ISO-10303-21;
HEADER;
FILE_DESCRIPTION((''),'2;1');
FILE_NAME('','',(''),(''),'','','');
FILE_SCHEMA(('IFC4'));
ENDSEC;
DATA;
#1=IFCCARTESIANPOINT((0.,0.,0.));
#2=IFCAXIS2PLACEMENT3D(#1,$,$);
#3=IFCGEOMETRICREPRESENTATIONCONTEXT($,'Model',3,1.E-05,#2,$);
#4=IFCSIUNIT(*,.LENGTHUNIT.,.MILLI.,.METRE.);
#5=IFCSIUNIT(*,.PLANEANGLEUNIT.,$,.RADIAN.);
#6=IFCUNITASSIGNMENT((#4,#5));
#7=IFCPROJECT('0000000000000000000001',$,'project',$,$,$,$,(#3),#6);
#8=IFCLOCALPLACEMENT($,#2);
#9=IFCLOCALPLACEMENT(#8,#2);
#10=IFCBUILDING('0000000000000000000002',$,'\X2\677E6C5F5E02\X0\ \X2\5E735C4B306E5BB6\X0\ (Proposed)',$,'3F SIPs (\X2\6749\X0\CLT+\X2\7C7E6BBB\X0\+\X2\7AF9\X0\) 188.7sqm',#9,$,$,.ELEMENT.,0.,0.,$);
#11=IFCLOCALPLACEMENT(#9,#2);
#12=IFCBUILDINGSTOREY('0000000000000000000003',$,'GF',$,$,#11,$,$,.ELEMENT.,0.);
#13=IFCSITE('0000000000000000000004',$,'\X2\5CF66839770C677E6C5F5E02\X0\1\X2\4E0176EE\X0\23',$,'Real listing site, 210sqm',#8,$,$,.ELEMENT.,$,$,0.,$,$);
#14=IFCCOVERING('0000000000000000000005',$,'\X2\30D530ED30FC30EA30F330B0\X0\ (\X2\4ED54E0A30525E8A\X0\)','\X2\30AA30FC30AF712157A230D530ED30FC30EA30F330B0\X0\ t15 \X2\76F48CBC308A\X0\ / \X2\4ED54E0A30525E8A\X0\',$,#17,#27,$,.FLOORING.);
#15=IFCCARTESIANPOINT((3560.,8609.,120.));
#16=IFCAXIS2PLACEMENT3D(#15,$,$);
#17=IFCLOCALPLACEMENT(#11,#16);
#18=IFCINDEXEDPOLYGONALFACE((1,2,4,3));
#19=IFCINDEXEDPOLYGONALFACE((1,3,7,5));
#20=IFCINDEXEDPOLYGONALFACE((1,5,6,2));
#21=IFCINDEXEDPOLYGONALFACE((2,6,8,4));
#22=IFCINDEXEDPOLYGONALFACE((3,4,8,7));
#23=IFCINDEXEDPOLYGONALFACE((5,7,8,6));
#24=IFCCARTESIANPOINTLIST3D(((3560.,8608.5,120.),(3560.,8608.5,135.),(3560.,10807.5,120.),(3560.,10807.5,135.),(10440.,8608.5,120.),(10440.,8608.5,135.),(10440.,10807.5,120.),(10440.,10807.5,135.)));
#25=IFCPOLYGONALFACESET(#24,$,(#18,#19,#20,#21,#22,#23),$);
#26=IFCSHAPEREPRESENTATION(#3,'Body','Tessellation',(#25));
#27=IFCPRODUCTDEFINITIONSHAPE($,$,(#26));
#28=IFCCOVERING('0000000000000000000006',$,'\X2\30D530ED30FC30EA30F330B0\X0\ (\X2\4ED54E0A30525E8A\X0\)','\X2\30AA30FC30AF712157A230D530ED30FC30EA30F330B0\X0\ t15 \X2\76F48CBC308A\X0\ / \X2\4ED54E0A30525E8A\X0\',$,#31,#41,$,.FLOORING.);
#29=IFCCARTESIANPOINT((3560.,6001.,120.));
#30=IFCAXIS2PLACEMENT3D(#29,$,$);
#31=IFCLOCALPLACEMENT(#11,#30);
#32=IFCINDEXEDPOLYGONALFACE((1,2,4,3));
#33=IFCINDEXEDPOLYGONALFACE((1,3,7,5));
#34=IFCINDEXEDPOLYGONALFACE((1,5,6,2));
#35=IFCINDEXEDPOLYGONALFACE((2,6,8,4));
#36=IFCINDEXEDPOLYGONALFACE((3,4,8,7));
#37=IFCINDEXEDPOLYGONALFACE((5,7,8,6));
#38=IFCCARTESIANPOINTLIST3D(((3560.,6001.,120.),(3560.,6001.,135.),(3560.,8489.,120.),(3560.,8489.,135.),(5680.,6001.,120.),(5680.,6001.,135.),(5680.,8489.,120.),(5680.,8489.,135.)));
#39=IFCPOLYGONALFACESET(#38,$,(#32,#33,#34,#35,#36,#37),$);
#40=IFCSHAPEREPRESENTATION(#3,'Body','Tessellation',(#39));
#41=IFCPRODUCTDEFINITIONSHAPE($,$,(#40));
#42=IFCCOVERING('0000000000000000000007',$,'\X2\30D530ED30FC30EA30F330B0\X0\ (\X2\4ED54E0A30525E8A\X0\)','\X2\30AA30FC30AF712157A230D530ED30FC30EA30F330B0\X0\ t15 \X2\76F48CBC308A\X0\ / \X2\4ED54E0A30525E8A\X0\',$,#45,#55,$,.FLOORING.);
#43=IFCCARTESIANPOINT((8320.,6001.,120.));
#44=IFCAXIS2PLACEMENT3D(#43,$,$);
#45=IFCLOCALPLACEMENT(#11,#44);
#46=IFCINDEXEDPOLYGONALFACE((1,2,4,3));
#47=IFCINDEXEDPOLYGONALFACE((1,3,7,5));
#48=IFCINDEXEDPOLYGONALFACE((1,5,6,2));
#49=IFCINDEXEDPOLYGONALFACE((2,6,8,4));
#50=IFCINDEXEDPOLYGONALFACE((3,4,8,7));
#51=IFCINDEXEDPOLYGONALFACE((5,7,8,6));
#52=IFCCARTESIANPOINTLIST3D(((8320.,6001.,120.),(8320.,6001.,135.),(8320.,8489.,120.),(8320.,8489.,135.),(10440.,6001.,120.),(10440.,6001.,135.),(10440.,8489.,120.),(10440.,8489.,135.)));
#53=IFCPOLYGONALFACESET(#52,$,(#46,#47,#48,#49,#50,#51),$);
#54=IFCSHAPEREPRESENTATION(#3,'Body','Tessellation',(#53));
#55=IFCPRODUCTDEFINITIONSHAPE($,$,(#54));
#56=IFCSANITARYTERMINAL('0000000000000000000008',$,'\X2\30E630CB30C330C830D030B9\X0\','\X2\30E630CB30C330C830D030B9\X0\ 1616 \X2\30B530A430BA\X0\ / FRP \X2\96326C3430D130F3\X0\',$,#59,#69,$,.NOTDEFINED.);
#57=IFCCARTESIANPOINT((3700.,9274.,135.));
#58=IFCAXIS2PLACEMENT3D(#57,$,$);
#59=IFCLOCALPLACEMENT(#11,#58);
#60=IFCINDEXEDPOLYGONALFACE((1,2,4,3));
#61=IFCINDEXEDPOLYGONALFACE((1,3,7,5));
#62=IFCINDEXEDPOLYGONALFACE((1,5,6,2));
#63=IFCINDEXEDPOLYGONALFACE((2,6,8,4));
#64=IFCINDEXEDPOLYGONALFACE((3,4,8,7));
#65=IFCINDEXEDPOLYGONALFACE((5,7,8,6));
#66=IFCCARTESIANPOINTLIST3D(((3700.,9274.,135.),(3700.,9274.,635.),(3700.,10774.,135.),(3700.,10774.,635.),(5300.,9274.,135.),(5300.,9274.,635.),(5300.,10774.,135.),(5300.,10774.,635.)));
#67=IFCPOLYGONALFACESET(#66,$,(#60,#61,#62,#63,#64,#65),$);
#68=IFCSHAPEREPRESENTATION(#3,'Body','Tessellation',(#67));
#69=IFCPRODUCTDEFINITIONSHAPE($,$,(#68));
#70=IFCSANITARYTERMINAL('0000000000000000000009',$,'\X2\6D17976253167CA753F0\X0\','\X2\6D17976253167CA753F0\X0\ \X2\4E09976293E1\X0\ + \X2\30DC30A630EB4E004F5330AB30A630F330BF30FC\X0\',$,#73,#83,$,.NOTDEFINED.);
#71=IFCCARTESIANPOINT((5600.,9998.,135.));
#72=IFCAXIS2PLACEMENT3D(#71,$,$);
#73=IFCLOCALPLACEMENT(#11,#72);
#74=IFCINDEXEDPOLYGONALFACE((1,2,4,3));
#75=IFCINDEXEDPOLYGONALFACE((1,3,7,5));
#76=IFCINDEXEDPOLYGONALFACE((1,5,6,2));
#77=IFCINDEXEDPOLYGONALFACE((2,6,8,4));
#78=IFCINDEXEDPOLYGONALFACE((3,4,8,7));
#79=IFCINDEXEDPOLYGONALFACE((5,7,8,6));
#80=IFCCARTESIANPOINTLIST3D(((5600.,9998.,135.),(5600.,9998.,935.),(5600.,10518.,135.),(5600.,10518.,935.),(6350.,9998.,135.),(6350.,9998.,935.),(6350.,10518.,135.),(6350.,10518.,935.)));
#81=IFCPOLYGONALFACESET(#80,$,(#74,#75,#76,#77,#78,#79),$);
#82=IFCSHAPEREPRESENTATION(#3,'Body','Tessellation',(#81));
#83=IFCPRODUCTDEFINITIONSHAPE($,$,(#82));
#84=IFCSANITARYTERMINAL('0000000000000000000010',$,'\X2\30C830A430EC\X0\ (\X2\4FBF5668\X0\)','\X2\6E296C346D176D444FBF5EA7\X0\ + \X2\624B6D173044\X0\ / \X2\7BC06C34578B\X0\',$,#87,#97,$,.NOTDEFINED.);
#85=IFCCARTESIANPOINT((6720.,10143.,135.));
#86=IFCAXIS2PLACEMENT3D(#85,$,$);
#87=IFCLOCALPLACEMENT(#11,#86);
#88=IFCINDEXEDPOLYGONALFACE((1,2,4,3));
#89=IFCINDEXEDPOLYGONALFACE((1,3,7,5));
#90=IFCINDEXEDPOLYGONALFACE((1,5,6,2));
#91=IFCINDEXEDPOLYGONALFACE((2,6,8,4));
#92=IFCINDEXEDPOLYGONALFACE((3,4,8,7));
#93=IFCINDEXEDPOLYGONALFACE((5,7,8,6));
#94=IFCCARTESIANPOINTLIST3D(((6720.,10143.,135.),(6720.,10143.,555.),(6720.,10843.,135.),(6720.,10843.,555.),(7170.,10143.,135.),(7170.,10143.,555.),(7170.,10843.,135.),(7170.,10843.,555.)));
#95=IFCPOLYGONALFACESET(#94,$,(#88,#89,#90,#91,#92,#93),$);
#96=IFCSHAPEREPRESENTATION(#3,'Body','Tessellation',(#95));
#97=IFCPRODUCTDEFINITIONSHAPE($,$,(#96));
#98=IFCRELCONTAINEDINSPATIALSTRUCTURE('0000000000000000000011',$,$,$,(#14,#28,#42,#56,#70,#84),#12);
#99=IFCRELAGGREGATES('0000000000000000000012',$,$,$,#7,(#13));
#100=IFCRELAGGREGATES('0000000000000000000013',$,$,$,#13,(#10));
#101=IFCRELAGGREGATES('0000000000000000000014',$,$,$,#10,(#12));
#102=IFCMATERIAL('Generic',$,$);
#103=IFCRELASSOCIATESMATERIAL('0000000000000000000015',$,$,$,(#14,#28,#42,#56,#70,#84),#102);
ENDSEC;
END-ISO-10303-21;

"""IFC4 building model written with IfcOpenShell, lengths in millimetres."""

from ifc_helpers import new_model, si_unit, frame, frame_2d, origin, place, context, project, spatial, rectangle, extrude, material, element, save


model = new_model("IFC4")

# Units and contexts
model_context = context("Model", 3, precision=1e-05, world=origin())
ifc_project = project(units=[si_unit("LENGTHUNIT", "METRE", prefix="MILLI"), si_unit("PLANEANGLEUNIT", "RADIAN")], contexts=[model_context])

# Site, building, storey
site_placement = place(None, origin())
site = spatial("IfcSite", under=ifc_project, at=site_placement, Name="島根県松江市1丁目23", ObjectType="Real listing site, 210sqm", CompositionType="ELEMENT", RefElevation=0.0)
building_placement = place(site_placement, origin())
building = spatial("IfcBuilding", under=site, at=building_placement, Name="松江市 平屋の家 (Proposed)", ObjectType="3F SIPs (杉CLT+籾殻+竹) 188.7sqm", CompositionType="ELEMENT", ElevationOfRefHeight=0.0, ElevationOfTerrain=0.0)
storey_placement = place(building_placement, origin())
storey = spatial("IfcBuildingStorey", under=building, at=storey_placement, Name="GF", CompositionType="ELEMENT", Elevation=0.0)

# Coverings
ifc_material_1 = material(Name="Generic")
covering_1_placement = place(storey_placement, frame((3560.0, 8609.0, 120.0)))
element("IfcCovering", 1, at=covering_1_placement, inside=storey, material=ifc_material_1, Name="フローリング (仕上げ床)", Description="オーク無垢フローリング t15 直貼り / 仕上げ床", PredefinedType="FLOORING", context=model_context, shape_type="SweptSolid", body=[
    extrude(rectangle(XDim=6880.0, YDim=2199.0, at=frame_2d((3440.0, 1099.0))), frame((3560.0, 8609.0, 120.0)), (0.0, 0.0, 1.0), 15.0),
])
covering_2_placement = place(storey_placement, frame((3560.0, 6001.0, 120.0)))
element("IfcCovering", 2, at=covering_2_placement, inside=storey, material=ifc_material_1, Name="フローリング (仕上げ床)", Description="オーク無垢フローリング t15 直貼り / 仕上げ床", PredefinedType="FLOORING", context=model_context, shape_type="SweptSolid", body=[
    extrude(rectangle(XDim=2120.0, YDim=2488.0, at=frame_2d((1060.0, 1244.0))), frame((3560.0, 6001.0, 120.0)), (0.0, 0.0, 1.0), 15.0),
])
covering_3_placement = place(storey_placement, frame((8320.0, 6001.0, 120.0)))
element("IfcCovering", 3, at=covering_3_placement, inside=storey, material=ifc_material_1, Name="フローリング (仕上げ床)", Description="オーク無垢フローリング t15 直貼り / 仕上げ床", PredefinedType="FLOORING", context=model_context, shape_type="SweptSolid", body=[
    extrude(rectangle(XDim=2120.0, YDim=2488.0, at=frame_2d((1060.0, 1244.0))), frame((8320.0, 6001.0, 120.0)), (0.0, 0.0, 1.0), 15.0),
])

# Sanitary terminals
sanitary_terminal_1_placement = place(storey_placement, frame((3700.0, 9274.0, 135.0)))
element("IfcSanitaryTerminal", 4, at=sanitary_terminal_1_placement, inside=storey, material=ifc_material_1, Name="ユニットバス", Description="ユニットバス 1616 サイズ / FRP 防水パン", PredefinedType="NOTDEFINED", context=model_context, shape_type="SweptSolid", body=[
    extrude(rectangle(XDim=1600.0, YDim=1500.0, at=frame_2d((800.0, 750.0))), frame((3700.0, 9274.0, 135.0)), (0.0, 0.0, 1.0), 500.0),
])
sanitary_terminal_2_placement = place(storey_placement, frame((5600.0, 9998.0, 135.0)))
element("IfcSanitaryTerminal", 5, at=sanitary_terminal_2_placement, inside=storey, material=ifc_material_1, Name="洗面化粧台", Description="洗面化粧台 三面鏡 + ボウル一体カウンター", PredefinedType="NOTDEFINED", context=model_context, shape_type="SweptSolid", body=[
    extrude(rectangle(XDim=750.0, YDim=520.0, at=frame_2d((375.0, 260.0))), frame((5600.0, 9998.0, 135.0)), (0.0, 0.0, 1.0), 800.0),
])
sanitary_terminal_3_placement = place(storey_placement, frame((6720.0, 10143.0, 135.0)))
element("IfcSanitaryTerminal", 6, at=sanitary_terminal_3_placement, inside=storey, material=ifc_material_1, Name="トイレ (便器)", Description="温水洗浄便座 + 手洗い / 節水型", PredefinedType="NOTDEFINED", context=model_context, shape_type="SweptSolid", body=[
    extrude(rectangle(XDim=450.0, YDim=700.0, at=frame_2d((225.0, 350.0))), frame((6720.0, 10143.0, 135.0)), (0.0, 0.0, 1.0), 420.0),
])

save(model, "model.ifc")
